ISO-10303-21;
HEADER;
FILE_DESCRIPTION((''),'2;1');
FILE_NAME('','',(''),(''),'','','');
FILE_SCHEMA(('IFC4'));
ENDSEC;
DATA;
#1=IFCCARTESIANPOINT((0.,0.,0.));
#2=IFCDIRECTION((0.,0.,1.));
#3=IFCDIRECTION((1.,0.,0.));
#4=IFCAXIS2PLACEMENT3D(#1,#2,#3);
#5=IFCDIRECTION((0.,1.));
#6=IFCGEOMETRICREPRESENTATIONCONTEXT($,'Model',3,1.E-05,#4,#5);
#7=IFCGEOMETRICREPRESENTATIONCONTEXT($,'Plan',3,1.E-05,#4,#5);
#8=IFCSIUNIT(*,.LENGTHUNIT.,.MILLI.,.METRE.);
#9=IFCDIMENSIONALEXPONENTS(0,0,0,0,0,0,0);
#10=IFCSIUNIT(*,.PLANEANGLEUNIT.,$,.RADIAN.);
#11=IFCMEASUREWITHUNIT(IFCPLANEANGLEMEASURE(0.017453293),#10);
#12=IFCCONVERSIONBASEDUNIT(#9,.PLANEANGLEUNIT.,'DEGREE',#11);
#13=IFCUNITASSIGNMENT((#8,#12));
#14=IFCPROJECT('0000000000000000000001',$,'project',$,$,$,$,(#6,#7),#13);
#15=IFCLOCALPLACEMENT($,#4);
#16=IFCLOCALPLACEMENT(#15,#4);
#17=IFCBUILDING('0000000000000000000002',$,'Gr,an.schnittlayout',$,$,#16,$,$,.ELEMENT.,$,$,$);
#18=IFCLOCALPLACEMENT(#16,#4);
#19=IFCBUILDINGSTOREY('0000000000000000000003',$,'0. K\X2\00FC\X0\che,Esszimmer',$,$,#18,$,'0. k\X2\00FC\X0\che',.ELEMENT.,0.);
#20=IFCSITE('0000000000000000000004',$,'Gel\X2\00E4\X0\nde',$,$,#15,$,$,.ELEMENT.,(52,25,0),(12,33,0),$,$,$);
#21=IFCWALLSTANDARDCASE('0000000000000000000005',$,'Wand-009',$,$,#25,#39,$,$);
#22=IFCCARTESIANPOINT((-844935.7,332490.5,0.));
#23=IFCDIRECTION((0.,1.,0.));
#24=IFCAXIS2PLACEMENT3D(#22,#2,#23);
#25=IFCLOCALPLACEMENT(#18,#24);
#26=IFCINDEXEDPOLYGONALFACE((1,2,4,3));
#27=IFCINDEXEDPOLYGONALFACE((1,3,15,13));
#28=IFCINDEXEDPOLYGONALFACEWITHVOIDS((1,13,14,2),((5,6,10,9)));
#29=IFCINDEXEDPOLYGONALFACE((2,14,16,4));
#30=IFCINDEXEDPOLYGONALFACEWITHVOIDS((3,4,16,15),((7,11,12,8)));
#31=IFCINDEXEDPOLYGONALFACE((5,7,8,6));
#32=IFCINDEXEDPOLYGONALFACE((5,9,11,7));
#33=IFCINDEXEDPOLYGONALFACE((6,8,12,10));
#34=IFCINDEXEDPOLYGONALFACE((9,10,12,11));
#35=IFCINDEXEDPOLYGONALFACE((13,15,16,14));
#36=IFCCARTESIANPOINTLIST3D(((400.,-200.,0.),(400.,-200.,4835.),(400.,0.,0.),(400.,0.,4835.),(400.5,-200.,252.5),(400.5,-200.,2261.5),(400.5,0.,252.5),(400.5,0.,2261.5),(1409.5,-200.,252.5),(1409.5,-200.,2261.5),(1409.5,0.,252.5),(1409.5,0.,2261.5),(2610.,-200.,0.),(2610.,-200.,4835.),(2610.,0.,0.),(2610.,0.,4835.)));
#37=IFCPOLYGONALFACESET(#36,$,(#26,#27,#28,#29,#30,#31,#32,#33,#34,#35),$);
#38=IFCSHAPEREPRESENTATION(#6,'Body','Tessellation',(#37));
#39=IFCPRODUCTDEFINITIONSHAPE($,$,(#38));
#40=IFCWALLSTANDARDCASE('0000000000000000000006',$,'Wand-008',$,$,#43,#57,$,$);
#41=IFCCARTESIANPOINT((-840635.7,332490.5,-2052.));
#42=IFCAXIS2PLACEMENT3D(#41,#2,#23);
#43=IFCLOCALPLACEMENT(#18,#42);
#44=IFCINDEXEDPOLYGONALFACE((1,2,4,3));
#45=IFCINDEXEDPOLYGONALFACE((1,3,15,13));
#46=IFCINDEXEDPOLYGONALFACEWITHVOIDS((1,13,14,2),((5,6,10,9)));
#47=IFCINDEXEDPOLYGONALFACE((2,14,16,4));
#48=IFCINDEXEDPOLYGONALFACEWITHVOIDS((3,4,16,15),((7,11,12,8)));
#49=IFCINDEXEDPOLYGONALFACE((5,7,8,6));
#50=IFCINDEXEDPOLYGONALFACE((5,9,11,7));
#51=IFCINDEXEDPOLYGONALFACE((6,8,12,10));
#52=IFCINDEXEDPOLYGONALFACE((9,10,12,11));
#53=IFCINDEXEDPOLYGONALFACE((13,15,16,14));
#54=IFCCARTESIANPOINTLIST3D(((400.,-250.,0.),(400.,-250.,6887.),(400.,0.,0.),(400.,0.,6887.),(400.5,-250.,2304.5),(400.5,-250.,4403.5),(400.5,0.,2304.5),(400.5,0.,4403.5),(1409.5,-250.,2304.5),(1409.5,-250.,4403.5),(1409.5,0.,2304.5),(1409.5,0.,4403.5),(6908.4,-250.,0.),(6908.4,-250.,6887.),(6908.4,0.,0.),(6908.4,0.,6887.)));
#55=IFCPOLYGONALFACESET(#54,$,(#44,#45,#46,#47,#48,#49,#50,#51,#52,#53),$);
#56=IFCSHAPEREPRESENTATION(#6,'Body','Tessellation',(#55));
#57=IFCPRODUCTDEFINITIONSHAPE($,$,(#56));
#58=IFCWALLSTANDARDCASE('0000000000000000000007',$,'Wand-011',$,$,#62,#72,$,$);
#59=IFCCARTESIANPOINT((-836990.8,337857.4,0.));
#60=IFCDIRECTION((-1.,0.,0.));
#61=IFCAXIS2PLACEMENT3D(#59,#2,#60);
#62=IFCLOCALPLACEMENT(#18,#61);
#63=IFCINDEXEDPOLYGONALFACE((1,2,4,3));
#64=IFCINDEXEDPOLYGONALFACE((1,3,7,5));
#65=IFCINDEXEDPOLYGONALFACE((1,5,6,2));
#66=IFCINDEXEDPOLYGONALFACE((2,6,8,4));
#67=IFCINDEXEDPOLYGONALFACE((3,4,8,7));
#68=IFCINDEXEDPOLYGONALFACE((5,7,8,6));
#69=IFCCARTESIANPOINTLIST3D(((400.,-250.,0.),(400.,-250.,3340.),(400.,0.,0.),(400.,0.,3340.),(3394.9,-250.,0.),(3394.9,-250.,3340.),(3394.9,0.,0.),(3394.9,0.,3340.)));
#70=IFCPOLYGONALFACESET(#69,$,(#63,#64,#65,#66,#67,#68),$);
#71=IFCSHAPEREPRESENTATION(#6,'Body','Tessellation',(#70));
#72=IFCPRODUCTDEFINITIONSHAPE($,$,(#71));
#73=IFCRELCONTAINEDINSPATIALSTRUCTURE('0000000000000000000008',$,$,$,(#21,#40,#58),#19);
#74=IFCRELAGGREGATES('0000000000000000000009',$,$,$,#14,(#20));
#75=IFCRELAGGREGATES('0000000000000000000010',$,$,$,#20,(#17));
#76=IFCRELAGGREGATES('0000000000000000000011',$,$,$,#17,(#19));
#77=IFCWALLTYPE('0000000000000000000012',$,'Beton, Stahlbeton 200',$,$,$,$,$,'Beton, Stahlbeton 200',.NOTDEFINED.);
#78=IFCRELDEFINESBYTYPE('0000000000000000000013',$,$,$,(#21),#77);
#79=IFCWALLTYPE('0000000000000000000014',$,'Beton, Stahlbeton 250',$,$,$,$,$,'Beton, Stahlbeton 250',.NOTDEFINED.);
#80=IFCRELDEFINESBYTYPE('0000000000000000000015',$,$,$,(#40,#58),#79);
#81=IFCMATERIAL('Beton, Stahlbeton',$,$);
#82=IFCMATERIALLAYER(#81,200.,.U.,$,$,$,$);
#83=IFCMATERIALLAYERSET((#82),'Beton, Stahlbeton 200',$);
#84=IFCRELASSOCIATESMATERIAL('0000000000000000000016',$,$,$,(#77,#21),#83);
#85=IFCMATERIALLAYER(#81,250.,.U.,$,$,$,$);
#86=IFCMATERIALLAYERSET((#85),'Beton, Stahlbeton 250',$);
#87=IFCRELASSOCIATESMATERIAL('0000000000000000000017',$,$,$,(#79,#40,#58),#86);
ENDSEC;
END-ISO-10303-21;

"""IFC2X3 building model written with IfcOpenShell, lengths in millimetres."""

from ifc_helpers import new_model, entity, si_unit, converted_unit, direction, frame, frame_2d, origin_with_axes, place, context, project, spatial, polyline, rectangle, outline, extrude, material, layer, layer_set, layer_usage, type_object, element, save


model = new_model("IFC2X3")

# Units and contexts
model_context = context("Model", 3, precision=1e-05, world=origin_with_axes(), true_north=direction((0.0, 1.0)))
plan_context = context("Plan", 3, precision=1e-05, world=origin_with_axes(), true_north=direction((0.0, 1.0)))
ifc_project = project(units=[si_unit("LENGTHUNIT", "METRE", prefix="MILLI"), converted_unit("PLANEANGLEUNIT", "DEGREE", entity("IfcPlaneAngleMeasure", 0.017453293), si_unit("PLANEANGLEUNIT", "RADIAN"), dimensions=[0, 0, 0, 0, 0, 0, 0])], contexts=[model_context, plan_context])

# Site, building, storey
site_placement = place(None, origin_with_axes())
site = spatial("IfcSite", under=ifc_project, at=site_placement, Name="Gelände", CompositionType="ELEMENT", RefLatitude=(52, 25, 0), RefLongitude=(12, 33, 0))
building_placement = place(site_placement, origin_with_axes())
building = spatial("IfcBuilding", under=site, at=building_placement, Name="Gr,an.schnittlayout", CompositionType="ELEMENT")
storey_placement = place(building_placement, origin_with_axes())
storey = spatial("IfcBuildingStorey", under=building, at=storey_placement, Name="0. Küche,Esszimmer", LongName="0. küche", CompositionType="ELEMENT", Elevation=0.0)

# Shared definitions
ifc_material = material(Name="Beton, Stahlbeton")

# Shared definitions
ifc_layer_1 = layer(ifc_material, 200.0, ventilated="UNKNOWN")
ifc_layer_set_1 = layer_set([ifc_layer_1], Name="Beton, Stahlbeton 200")
wall_type_1 = type_object("IfcWallType", Name="Beton, Stahlbeton 200", ElementType="Beton, Stahlbeton 200", PredefinedType="NOTDEFINED", material=ifc_layer_set_1)

# Walls, openings
ifc_layer_usage_1 = layer_usage(ifc_layer_set_1, "AXIS2", "NEGATIVE", 0.0)
wall_1_placement = place(storey_placement, frame((-844935.7, 332490.5, 0.0), z_axis=(0.0, 0.0, 1.0), x_axis=(0.0, 1.0, 0.0)))
wall_1 = element("IfcWallStandardCase", 1, at=wall_1_placement, inside=storey, type_object=wall_type_1, material=ifc_layer_usage_1, Name="Wand-009", context=model_context, shape_type="SweptSolid", body=[
    extrude(outline(polyline([(400.0, -200.0), (2610.0, -200.0), (2610.0, 0.0), (400.0, 0.0), (400.0, -200.0)])), origin_with_axes(), (0.0, 0.0, 1.0), 4835.0),
])
opening_1_placement = place(wall_1_placement, frame((905.0, -200.0, 252.0), z_axis=(0.0, 0.0, 1.0), x_axis=(1.0, 0.0, 0.0)))
element("IfcOpeningElement", 2, at=opening_1_placement, cuts=wall_1, ObjectType="Opening", context=model_context, shape_type="SweptSolid", body=[
    extrude(rectangle(XDim=1009.0, YDim=2009.0, at=frame_2d((0.0, 1005.0), x_axis=(1.0, 0.0))), frame((0.0, 0.0, 0.0), z_axis=(0.0, 1.0, 0.0), x_axis=(-1.0, 0.0, 0.0)), (0.0, 0.0, 1.0), 200.0),
])
ifc_layer_2 = layer(ifc_material, 250.0, ventilated="UNKNOWN")
ifc_layer_set_2 = layer_set([ifc_layer_2], Name="Beton, Stahlbeton 250")
ifc_layer_usage_2 = layer_usage(ifc_layer_set_2, "AXIS2", "NEGATIVE", 0.0)
wall_type_2 = type_object("IfcWallType", Name="Beton, Stahlbeton 250", ElementType="Beton, Stahlbeton 250", PredefinedType="NOTDEFINED", material=ifc_layer_set_2)
wall_2_placement = place(storey_placement, frame((-840635.7, 332490.5, -2052.0), z_axis=(0.0, 0.0, 1.0), x_axis=(0.0, 1.0, 0.0)))
wall_2 = element("IfcWallStandardCase", 3, at=wall_2_placement, inside=storey, type_object=wall_type_2, material=ifc_layer_usage_2, Name="Wand-008", context=model_context, shape_type="SweptSolid", body=[
    extrude(outline(polyline([(400.0, -250.0), (6908.4, -250.0), (6908.4, 0.0), (400.0, 0.0), (400.0, -250.0)])), origin_with_axes(), (0.0, 0.0, 1.0), 6887.0),
])
opening_2_placement = place(wall_2_placement, frame((905.0, -250.0, 2304.0), z_axis=(0.0, 0.0, 1.0), x_axis=(1.0, 0.0, 0.0)))
element("IfcOpeningElement", 4, at=opening_2_placement, cuts=wall_2, ObjectType="Opening", context=model_context, shape_type="SweptSolid", body=[
    extrude(rectangle(XDim=1009.0, YDim=2099.0, at=frame_2d((0.0, 1050.0), x_axis=(1.0, 0.0))), frame((0.0, 0.0, 0.0), z_axis=(0.0, 1.0, 0.0), x_axis=(-1.0, 0.0, 0.0)), (0.0, 0.0, 1.0), 250.0),
])

# Wall
ifc_layer_usage_3 = layer_usage(ifc_layer_set_2, "AXIS2", "NEGATIVE", 0.0)
wall_3_placement = place(storey_placement, frame((-836990.8, 337857.4, 0.0), z_axis=(0.0, 0.0, 1.0), x_axis=(-1.0, 0.0, 0.0)))
element("IfcWallStandardCase", 5, at=wall_3_placement, inside=storey, type_object=wall_type_2, material=ifc_layer_usage_3, Name="Wand-011", context=model_context, shape_type="SweptSolid", body=[
    extrude(outline(polyline([(400.0, -250.0), (3394.9, -250.0), (3394.9, 0.0), (400.0, 0.0), (400.0, -250.0)])), origin_with_axes(), (0.0, 0.0, 1.0), 3340.0),
])

save(model, "model.ifc")
